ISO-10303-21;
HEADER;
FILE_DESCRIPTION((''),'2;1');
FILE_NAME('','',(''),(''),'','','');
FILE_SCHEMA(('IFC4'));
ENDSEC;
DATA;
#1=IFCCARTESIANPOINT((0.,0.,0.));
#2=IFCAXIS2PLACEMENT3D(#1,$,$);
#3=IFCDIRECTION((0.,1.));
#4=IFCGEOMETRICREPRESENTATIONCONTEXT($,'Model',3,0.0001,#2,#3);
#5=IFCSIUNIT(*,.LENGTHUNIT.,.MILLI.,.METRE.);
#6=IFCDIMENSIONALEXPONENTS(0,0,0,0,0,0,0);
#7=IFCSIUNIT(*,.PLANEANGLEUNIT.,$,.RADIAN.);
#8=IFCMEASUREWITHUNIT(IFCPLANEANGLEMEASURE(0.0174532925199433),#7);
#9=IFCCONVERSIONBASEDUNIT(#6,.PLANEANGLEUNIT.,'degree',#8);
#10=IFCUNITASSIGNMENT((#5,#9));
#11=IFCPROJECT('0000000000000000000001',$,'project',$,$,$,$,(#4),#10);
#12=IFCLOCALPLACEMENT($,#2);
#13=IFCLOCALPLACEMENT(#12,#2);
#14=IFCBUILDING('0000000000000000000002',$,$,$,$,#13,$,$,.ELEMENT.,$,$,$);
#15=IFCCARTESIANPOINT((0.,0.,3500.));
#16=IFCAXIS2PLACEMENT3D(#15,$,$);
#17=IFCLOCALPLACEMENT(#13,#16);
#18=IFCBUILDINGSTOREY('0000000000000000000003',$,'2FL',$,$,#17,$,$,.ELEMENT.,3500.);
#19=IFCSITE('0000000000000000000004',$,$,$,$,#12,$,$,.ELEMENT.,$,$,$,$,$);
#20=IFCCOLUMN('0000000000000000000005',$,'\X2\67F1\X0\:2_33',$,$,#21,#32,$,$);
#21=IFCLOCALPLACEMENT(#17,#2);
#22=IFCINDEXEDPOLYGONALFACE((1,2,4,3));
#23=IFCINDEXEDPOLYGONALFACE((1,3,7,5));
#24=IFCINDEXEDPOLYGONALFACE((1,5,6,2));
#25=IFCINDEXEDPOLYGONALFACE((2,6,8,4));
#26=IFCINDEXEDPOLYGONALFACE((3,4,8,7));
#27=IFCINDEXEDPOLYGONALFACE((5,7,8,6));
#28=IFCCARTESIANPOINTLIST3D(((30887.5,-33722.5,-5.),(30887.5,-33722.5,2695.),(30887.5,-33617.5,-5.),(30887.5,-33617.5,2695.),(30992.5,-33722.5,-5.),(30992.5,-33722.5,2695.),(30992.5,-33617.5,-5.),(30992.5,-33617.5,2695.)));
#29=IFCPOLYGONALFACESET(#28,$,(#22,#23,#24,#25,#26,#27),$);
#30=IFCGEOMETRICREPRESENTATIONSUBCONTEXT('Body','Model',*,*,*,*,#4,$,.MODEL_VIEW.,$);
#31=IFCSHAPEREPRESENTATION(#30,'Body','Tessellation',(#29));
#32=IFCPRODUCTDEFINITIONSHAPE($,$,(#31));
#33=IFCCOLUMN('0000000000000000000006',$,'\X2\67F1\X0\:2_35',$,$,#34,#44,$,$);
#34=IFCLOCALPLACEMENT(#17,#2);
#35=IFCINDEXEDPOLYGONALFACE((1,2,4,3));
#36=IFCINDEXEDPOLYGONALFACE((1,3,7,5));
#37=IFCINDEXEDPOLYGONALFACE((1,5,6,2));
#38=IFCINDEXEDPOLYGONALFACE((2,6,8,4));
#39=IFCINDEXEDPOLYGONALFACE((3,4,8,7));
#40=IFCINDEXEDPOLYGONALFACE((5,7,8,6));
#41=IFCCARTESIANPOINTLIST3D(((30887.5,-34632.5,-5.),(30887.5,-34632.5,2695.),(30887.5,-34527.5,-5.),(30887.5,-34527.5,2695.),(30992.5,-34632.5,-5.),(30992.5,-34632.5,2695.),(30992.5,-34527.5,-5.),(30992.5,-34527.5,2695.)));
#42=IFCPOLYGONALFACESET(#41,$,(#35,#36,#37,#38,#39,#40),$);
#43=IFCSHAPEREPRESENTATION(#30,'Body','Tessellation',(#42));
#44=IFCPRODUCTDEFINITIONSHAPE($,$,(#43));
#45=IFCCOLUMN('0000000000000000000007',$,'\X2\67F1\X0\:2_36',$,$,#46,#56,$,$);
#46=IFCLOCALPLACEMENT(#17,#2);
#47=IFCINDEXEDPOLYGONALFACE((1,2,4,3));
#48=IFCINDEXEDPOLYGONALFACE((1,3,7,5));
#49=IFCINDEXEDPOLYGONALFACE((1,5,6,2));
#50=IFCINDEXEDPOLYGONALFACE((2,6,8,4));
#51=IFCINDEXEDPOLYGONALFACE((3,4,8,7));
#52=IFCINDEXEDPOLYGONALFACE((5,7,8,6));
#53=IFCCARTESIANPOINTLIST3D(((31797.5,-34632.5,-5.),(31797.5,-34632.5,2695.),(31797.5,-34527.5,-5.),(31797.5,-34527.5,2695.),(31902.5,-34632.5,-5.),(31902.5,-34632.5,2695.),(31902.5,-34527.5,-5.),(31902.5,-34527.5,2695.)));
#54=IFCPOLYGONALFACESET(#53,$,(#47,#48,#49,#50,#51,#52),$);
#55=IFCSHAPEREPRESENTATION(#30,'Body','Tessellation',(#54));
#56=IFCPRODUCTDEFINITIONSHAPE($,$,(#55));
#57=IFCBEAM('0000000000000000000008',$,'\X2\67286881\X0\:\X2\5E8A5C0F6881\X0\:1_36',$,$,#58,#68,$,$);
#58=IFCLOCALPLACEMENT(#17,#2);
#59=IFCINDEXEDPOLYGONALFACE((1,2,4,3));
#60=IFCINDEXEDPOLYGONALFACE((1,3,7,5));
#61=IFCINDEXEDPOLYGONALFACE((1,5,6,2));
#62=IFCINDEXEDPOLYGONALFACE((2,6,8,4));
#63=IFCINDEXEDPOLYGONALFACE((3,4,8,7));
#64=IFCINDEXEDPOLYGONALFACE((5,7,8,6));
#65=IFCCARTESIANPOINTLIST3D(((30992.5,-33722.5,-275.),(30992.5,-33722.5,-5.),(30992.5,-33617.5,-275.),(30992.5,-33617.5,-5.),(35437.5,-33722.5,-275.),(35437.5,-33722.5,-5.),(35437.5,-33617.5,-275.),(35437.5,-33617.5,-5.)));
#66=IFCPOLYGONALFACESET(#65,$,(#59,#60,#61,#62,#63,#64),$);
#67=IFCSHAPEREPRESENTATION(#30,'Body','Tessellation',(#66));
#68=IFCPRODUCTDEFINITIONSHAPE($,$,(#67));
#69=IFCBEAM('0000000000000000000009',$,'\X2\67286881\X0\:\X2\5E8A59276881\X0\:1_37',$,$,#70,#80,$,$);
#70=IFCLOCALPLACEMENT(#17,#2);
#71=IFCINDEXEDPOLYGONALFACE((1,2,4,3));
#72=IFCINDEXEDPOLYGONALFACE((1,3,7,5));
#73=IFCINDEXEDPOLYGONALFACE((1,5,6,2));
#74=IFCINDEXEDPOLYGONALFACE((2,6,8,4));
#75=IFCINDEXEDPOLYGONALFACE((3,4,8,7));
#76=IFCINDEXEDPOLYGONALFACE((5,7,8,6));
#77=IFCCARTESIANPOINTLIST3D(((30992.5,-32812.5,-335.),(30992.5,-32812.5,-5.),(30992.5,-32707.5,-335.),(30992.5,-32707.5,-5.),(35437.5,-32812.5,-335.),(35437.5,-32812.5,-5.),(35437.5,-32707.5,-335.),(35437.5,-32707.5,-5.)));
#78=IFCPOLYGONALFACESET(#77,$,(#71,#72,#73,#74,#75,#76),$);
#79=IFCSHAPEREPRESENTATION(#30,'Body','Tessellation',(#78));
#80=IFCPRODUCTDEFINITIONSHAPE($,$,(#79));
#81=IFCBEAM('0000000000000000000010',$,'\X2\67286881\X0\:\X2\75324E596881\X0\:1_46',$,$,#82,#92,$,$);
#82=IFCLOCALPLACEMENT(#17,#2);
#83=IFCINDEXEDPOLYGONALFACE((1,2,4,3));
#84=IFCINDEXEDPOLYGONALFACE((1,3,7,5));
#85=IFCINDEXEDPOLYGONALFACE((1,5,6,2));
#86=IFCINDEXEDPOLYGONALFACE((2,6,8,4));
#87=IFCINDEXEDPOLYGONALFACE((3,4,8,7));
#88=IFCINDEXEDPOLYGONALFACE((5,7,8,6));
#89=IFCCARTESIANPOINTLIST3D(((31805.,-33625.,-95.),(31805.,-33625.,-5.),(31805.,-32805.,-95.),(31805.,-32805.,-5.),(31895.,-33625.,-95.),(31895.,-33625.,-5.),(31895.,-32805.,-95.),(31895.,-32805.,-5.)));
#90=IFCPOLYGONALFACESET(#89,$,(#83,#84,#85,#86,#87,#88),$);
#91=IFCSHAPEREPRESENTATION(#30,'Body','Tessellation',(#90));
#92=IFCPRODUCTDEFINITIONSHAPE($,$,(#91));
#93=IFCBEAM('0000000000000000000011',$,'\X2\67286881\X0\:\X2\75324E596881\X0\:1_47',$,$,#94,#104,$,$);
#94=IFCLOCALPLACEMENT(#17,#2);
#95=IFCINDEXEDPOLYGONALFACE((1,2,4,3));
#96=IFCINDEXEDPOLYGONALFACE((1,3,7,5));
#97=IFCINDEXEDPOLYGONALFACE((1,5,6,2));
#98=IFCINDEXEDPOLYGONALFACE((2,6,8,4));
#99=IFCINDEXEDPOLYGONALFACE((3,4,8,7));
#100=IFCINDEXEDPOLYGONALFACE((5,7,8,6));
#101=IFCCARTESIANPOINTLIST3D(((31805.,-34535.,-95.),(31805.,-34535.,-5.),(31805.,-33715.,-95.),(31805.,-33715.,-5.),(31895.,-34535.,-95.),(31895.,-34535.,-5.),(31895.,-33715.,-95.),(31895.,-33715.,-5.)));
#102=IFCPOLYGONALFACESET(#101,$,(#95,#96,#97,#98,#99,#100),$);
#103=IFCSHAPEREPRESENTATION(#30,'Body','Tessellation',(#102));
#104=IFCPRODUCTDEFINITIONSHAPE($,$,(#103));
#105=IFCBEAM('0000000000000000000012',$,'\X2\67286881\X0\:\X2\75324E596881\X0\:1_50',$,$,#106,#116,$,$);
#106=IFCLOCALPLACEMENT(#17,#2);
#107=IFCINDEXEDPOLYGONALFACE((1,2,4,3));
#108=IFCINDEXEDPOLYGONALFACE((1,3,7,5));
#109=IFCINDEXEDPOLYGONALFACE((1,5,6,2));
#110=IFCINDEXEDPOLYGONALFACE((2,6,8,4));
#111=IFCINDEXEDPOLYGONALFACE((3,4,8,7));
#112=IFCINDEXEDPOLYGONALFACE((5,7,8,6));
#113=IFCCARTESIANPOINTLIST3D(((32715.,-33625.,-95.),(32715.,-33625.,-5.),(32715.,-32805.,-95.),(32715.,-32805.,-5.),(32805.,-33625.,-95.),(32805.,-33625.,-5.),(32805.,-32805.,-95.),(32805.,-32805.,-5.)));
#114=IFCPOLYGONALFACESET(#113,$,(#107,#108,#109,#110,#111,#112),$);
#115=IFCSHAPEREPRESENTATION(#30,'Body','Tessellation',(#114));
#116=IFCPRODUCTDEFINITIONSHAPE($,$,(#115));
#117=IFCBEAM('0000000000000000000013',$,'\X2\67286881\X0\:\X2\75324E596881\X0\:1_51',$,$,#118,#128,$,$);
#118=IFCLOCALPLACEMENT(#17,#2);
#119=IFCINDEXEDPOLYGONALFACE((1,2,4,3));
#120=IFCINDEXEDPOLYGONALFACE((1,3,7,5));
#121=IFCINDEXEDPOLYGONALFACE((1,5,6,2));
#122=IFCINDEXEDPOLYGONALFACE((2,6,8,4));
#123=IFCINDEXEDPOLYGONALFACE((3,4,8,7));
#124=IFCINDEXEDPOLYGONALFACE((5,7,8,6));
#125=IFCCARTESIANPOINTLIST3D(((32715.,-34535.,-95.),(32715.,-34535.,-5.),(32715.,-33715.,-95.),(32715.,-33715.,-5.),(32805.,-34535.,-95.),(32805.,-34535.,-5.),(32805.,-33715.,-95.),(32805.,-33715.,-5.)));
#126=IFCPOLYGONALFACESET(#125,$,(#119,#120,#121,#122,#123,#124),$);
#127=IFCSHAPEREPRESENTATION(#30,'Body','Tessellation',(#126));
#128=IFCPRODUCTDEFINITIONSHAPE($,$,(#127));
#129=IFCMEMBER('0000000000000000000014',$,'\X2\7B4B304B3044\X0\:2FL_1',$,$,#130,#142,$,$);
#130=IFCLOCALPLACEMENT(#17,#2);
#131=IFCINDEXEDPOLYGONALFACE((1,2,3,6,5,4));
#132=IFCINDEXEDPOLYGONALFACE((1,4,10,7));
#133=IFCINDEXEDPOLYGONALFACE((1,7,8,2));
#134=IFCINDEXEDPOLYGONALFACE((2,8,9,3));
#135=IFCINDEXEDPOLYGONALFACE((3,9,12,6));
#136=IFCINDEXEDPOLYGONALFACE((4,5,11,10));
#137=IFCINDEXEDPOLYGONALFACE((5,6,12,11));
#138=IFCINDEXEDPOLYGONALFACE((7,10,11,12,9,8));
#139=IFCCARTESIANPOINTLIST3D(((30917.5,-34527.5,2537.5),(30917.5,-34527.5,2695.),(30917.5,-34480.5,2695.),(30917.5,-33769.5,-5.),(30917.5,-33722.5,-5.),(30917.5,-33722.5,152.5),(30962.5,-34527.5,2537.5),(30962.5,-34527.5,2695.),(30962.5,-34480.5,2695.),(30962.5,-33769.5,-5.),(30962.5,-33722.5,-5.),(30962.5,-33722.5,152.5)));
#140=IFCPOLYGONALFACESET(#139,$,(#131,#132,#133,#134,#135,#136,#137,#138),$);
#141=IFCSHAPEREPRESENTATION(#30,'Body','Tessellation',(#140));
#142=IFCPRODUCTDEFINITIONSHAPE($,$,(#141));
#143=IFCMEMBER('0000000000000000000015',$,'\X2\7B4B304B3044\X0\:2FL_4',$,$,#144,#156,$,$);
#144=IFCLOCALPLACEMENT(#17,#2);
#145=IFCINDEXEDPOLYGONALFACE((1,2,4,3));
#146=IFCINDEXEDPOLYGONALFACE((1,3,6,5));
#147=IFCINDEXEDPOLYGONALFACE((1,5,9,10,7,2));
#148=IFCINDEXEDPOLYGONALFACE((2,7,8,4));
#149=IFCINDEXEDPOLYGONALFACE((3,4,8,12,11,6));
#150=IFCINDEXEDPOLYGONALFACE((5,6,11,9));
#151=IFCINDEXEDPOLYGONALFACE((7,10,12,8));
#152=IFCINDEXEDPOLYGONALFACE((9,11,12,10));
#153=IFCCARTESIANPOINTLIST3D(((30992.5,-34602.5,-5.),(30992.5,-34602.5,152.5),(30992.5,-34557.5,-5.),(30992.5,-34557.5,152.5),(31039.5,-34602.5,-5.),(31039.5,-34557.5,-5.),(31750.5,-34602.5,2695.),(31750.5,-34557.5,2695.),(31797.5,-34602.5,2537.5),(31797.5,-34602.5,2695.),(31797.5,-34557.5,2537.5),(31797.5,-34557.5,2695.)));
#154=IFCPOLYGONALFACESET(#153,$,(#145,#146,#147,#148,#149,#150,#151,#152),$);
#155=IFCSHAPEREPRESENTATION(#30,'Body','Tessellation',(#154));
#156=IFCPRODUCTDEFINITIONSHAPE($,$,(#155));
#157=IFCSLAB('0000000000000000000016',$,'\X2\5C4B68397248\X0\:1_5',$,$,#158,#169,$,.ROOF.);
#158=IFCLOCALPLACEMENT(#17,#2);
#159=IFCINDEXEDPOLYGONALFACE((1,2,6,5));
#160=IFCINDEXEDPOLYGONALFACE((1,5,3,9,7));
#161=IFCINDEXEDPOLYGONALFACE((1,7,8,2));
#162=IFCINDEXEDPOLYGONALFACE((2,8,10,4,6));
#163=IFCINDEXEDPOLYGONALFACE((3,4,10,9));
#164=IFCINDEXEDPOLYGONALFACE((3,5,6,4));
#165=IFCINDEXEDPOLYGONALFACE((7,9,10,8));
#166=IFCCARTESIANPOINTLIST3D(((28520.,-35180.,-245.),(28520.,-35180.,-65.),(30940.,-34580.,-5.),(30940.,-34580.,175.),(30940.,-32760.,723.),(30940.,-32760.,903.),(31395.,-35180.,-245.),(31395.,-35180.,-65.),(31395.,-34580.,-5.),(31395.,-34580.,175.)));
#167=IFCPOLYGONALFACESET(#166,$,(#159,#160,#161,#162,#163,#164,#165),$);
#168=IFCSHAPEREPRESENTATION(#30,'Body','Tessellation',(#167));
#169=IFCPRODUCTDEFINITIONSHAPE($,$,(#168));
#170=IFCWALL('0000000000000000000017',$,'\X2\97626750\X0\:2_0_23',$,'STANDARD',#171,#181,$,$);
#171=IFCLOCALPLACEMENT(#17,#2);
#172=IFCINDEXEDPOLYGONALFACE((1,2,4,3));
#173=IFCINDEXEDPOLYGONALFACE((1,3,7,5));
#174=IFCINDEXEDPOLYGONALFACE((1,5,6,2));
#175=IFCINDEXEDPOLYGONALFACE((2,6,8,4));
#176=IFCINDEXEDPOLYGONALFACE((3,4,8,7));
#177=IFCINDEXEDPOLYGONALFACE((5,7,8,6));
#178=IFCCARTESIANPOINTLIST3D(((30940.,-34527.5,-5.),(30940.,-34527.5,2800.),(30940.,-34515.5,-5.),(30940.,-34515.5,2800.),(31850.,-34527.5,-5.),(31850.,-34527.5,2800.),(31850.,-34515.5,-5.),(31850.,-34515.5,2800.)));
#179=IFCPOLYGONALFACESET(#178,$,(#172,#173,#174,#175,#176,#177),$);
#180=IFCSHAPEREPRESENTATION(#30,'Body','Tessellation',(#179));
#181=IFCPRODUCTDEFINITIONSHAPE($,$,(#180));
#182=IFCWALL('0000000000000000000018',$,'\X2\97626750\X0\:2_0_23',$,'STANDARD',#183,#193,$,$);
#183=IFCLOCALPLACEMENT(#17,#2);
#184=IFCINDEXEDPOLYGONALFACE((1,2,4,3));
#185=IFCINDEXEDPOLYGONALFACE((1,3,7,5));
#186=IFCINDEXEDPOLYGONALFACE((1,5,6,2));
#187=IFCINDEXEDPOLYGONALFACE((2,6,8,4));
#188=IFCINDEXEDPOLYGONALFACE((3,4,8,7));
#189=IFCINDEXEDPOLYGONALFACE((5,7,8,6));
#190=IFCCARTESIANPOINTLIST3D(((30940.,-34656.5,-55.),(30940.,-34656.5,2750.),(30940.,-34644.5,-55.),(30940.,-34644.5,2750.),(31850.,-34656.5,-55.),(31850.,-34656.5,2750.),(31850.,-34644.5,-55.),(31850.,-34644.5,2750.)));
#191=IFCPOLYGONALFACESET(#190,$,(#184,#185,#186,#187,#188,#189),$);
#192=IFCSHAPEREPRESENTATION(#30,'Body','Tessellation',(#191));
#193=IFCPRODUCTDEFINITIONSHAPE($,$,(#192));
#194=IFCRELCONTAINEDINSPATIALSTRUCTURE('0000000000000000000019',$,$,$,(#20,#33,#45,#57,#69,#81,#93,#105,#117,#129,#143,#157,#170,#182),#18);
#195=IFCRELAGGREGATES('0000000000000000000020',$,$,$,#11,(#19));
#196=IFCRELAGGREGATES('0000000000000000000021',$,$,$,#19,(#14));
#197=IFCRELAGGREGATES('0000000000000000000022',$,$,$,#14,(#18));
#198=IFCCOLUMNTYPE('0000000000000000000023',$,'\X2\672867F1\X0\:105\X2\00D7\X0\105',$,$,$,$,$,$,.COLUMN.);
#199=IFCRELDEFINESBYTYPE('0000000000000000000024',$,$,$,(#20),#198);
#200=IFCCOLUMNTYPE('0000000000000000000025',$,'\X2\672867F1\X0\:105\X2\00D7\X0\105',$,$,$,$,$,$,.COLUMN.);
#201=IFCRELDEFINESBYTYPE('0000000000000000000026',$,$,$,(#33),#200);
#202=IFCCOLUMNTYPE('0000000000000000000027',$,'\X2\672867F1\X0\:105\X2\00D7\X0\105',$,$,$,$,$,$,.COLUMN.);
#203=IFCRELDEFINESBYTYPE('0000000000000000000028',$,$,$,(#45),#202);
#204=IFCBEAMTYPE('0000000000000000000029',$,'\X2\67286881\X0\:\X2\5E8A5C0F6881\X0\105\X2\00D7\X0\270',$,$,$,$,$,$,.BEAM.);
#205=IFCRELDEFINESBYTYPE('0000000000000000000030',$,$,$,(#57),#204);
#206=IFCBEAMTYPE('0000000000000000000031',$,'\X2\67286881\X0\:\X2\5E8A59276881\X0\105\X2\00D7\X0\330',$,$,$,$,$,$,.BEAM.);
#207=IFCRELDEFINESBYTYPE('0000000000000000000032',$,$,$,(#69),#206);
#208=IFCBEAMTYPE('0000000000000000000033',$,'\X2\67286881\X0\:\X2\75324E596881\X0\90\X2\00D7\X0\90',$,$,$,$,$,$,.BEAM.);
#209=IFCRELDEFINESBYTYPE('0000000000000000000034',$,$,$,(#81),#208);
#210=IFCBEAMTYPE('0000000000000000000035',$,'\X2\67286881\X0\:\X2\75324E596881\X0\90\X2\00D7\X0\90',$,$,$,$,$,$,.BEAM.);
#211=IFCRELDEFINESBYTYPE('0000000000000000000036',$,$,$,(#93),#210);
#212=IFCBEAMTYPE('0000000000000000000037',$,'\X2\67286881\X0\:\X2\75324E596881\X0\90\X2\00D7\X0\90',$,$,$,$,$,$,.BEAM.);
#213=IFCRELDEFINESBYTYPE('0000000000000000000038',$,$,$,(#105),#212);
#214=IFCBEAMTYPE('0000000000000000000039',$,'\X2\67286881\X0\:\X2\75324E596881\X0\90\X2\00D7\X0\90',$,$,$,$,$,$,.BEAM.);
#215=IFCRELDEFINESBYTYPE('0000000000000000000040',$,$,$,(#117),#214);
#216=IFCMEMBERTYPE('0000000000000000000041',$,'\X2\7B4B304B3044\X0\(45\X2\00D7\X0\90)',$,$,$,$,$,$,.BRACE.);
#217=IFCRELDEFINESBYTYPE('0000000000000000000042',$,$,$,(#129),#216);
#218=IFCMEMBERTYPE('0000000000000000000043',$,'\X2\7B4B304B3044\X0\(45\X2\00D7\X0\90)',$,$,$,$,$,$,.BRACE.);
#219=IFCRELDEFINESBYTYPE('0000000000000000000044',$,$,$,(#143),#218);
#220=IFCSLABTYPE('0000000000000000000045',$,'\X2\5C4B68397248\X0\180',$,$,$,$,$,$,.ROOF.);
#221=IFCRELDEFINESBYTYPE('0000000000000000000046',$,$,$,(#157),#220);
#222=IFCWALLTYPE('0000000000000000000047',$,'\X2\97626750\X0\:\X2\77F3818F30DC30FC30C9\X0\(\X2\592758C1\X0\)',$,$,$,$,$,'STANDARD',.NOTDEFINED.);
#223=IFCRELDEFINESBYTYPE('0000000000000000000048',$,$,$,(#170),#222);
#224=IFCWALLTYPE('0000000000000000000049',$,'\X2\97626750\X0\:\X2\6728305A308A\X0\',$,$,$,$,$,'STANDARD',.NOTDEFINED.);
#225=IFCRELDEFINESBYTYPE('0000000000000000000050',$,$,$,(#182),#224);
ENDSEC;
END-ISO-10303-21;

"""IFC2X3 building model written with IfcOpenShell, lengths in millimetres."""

from ifc_helpers import new_model, entity, si_unit, converted_unit, direction, frame, origin, origin_with_axes, origin_2d, place, context, subcontext, project, spatial, polyline, rectangle, outline, extrude, type_object, element, save


model = new_model("IFC2X3")

# Units and contexts
model_context = context("Model", 3, precision=0.0001, world=origin(), true_north=direction((0.0, 1.0)))
body_context = subcontext(model_context, "Body", "Model", "MODEL_VIEW")
ifc_project = project(units=[si_unit("LENGTHUNIT", "METRE", prefix="MILLI"), converted_unit("PLANEANGLEUNIT", "degree", entity("IfcPlaneAngleMeasure", 0.0174532925199433), si_unit("PLANEANGLEUNIT", "RADIAN"), dimensions=[0, 0, 0, 0, 0, 0, 0])], contexts=[model_context])

# Site, building, storey
site_placement = place(None, origin())
site = spatial("IfcSite", under=ifc_project, at=site_placement, CompositionType="ELEMENT")
building_placement = place(site_placement, origin())
building = spatial("IfcBuilding", under=site, at=building_placement, CompositionType="ELEMENT")
storey_placement = place(building_placement, frame((0.0, 0.0, 3500.0)))
storey = spatial("IfcBuildingStorey", under=building, at=storey_placement, Name="2FL", CompositionType="ELEMENT", Elevation=3500.0)

# Columns
column_type_1 = type_object("IfcColumnType", Name="木柱:105×105", PredefinedType="COLUMN")
column_1_placement = place(storey_placement, frame((30940.0, -33670.0, -5.0)))
element("IfcColumn", 1, at=column_1_placement, inside=storey, type_object=column_type_1, Name="柱:2_33", context=body_context, shape_type="SweptSolid", body=[
    extrude(rectangle(XDim=105.0, YDim=105.0, at=origin_2d()), origin_with_axes(), (0.0, 0.0, 1.0), 2700.0),
])
column_type_2 = type_object("IfcColumnType", Name="木柱:105×105", PredefinedType="COLUMN")
column_2_placement = place(storey_placement, frame((30940.0, -34580.0, -5.0)))
element("IfcColumn", 2, at=column_2_placement, inside=storey, type_object=column_type_2, Name="柱:2_35", context=body_context, shape_type="SweptSolid", body=[
    extrude(rectangle(XDim=105.0, YDim=105.0, at=origin_2d()), origin_with_axes(), (0.0, 0.0, 1.0), 2700.0),
])
column_type_3 = type_object("IfcColumnType", Name="木柱:105×105", PredefinedType="COLUMN")
column_3_placement = place(storey_placement, frame((31850.0, -34580.0, -5.0)))
element("IfcColumn", 3, at=column_3_placement, inside=storey, type_object=column_type_3, Name="柱:2_36", context=body_context, shape_type="SweptSolid", body=[
    extrude(rectangle(XDim=105.0, YDim=105.0, at=origin_2d()), origin_with_axes(), (0.0, 0.0, 1.0), 2700.0),
])

# Beams
beam_type_1 = type_object("IfcBeamType", Name="木梁:床小梁105×270", PredefinedType="BEAM")
beam_1_placement = place(storey_placement, frame((30992.5, -33670.0, -140.0), z_axis=(1.0, 0.0, 0.0), x_axis=(0.0, 1.0, 0.0)))
element("IfcBeam", 4, at=beam_1_placement, inside=storey, type_object=beam_type_1, Name="木梁:床小梁:1_36", context=body_context, shape_type="SweptSolid", body=[
    extrude(rectangle(XDim=105.0, YDim=270.0, at=origin_2d()), origin_with_axes(), (0.0, 0.0, 1.0), 4445.0),
])
beam_type_2 = type_object("IfcBeamType", Name="木梁:床大梁105×330", PredefinedType="BEAM")
beam_2_placement = place(storey_placement, frame((30992.5, -32760.0, -170.0), z_axis=(1.0, 0.0, 0.0), x_axis=(0.0, 1.0, 0.0)))
element("IfcBeam", 5, at=beam_2_placement, inside=storey, type_object=beam_type_2, Name="木梁:床大梁:1_37", context=body_context, shape_type="SweptSolid", body=[
    extrude(rectangle(XDim=105.0, YDim=330.0, at=origin_2d()), origin_with_axes(), (0.0, 0.0, 1.0), 4445.0),
])
beam_type_3 = type_object("IfcBeamType", Name="木梁:甲乙梁90×90", PredefinedType="BEAM")
beam_3_placement = place(storey_placement, frame((31850.0, -32805.0, -50.0), z_axis=(0.0, -1.0, 0.0), x_axis=(1.0, 0.0, 0.0)))
element("IfcBeam", 6, at=beam_3_placement, inside=storey, type_object=beam_type_3, Name="木梁:甲乙梁:1_46", context=body_context, shape_type="SweptSolid", body=[
    extrude(rectangle(XDim=90.0, YDim=90.0, at=origin_2d()), origin_with_axes(), (0.0, 0.0, 1.0), 820.0),
])
beam_type_4 = type_object("IfcBeamType", Name="木梁:甲乙梁90×90", PredefinedType="BEAM")
beam_4_placement = place(storey_placement, frame((31850.0, -33715.0, -50.0), z_axis=(0.0, -1.0, 0.0), x_axis=(1.0, 0.0, 0.0)))
element("IfcBeam", 7, at=beam_4_placement, inside=storey, type_object=beam_type_4, Name="木梁:甲乙梁:1_47", context=body_context, shape_type="SweptSolid", body=[
    extrude(rectangle(XDim=90.0, YDim=90.0, at=origin_2d()), origin_with_axes(), (0.0, 0.0, 1.0), 820.0),
])
beam_type_5 = type_object("IfcBeamType", Name="木梁:甲乙梁90×90", PredefinedType="BEAM")
beam_5_placement = place(storey_placement, frame((32760.0, -32805.0, -50.0), z_axis=(0.0, -1.0, 0.0), x_axis=(1.0, 0.0, 0.0)))
element("IfcBeam", 8, at=beam_5_placement, inside=storey, type_object=beam_type_5, Name="木梁:甲乙梁:1_50", context=body_context, shape_type="SweptSolid", body=[
    extrude(rectangle(XDim=90.0, YDim=90.0, at=origin_2d()), origin_with_axes(), (0.0, 0.0, 1.0), 820.0),
])
beam_type_6 = type_object("IfcBeamType", Name="木梁:甲乙梁90×90", PredefinedType="BEAM")
beam_6_placement = place(storey_placement, frame((32760.0, -33715.0, -50.0), z_axis=(0.0, -1.0, 0.0), x_axis=(1.0, 0.0, 0.0)))
element("IfcBeam", 9, at=beam_6_placement, inside=storey, type_object=beam_type_6, Name="木梁:甲乙梁:1_51", context=body_context, shape_type="SweptSolid", body=[
    extrude(rectangle(XDim=90.0, YDim=90.0, at=origin_2d()), origin_with_axes(), (0.0, 0.0, 1.0), 820.0),
])

# Members
member_type_1 = type_object("IfcMemberType", Name="筋かい(45×90)", PredefinedType="BRACE")
member_1_placement = place(storey_placement, frame((30940.0, -33722.5, -5.0), z_axis=(0.0, -0.285719, 0.958313), x_axis=(0.0, 0.958313, 0.285719)))
element("IfcMember", 10, at=member_1_placement, inside=storey, type_object=member_type_1, Name="筋かい:2FL_1", context=body_context, shape_type="SweptSolid", body=[
    extrude(outline(polyline([(0.0, 0.0), (13.4, -45.0), (2666.5, -45.0), (2817.5, 0.0), (2804.0, 45.0), (150.9, 45.0), (0.0, 0.0)])), frame((0.0, -22.5, 0.0), z_axis=(0.0, 1.0, 0.0), x_axis=(0.0, 0.0, 1.0)), (0.0, 0.0, 1.0), 45.0),
])
member_type_2 = type_object("IfcMemberType", Name="筋かい(45×90)", PredefinedType="BRACE")
member_2_placement = place(storey_placement, frame((30992.5, -34580.0, -5.0), z_axis=(0.285719, 0.0, 0.958313), x_axis=(-0.958313, 0.0, 0.285719)))
element("IfcMember", 11, at=member_2_placement, inside=storey, type_object=member_type_2, Name="筋かい:2FL_4", context=body_context, shape_type="SweptSolid", body=[
    extrude(outline(polyline([(0.0, 0.0), (13.4, -45.0), (2666.5, -45.0), (2817.5, 0.0), (2804.0, 45.0), (150.9, 45.0), (0.0, 0.0)])), frame((0.0, -22.5, 0.0), z_axis=(0.0, 1.0, 0.0), x_axis=(0.0, 0.0, 1.0)), (0.0, 0.0, 1.0), 45.0),
])

# Slab
slab_type = type_object("IfcSlabType", Name="屋根版180", PredefinedType="ROOF")
slab_placement = place(storey_placement, frame((30940.0, -32760.0, 723.0), z_axis=(0.0, -0.371391, 0.928477), x_axis=(0.0, -0.928477, -0.371391)))
element("IfcSlab", 12, at=slab_placement, inside=storey, type_object=slab_type, Name="屋根版:1_5", PredefinedType="ROOF", context=body_context, shape_type="SweptSolid", body=[
    extrude(outline(polyline([(0.0, 0.0, 0.0), (1960.2, 0.0, 0.0), (1960.2, 455.0, 0.0), (2606.4, 455.0, 0.0), (2606.4, -2420.0, 0.0), (0.0, 0.0, 0.0)])), origin_with_axes(), (-0.371391, 0.0, 0.928477), 180.0),
])

# Walls
wall_type_1 = type_object("IfcWallType", Name="面材:石膏ボード(大壁)", ElementType="STANDARD", PredefinedType="NOTDEFINED")
wall_1_placement = place(storey_placement, frame((31395.0, -34515.5, -5.0), z_axis=(0.0, -1.0, 0.0), x_axis=(1.0, 0.0, 0.0)))
element("IfcWall", 13, at=wall_1_placement, inside=storey, type_object=wall_type_1, Name="面材:2_0_23", ObjectType="STANDARD", context=body_context, shape_type="SweptSolid", body=[
    extrude(outline(polyline([(455.0, 0.0, 0.0), (-455.0, 0.0, 0.0), (-455.0, 2805.0, 0.0), (455.0, 2805.0, 0.0), (455.0, 0.0, 0.0)])), origin_with_axes(), (0.0, 0.0, 1.0), 12.0),
])
wall_type_2 = type_object("IfcWallType", Name="面材:木ずり", ElementType="STANDARD", PredefinedType="NOTDEFINED")
wall_2_placement = place(storey_placement, frame((31395.0, -34644.5, -55.0), z_axis=(0.0, -1.0, 0.0), x_axis=(1.0, 0.0, 0.0)))
element("IfcWall", 14, at=wall_2_placement, inside=storey, type_object=wall_type_2, Name="面材:2_0_23", ObjectType="STANDARD", context=body_context, shape_type="SweptSolid", body=[
    extrude(outline(polyline([(455.0, 0.0, 0.0), (-455.0, 0.0, 0.0), (-455.0, 2805.0, 0.0), (455.0, 2805.0, 0.0), (455.0, 0.0, 0.0)])), origin_with_axes(), (0.0, 0.0, 1.0), 12.0),
])

save(model, "model.ifc")
